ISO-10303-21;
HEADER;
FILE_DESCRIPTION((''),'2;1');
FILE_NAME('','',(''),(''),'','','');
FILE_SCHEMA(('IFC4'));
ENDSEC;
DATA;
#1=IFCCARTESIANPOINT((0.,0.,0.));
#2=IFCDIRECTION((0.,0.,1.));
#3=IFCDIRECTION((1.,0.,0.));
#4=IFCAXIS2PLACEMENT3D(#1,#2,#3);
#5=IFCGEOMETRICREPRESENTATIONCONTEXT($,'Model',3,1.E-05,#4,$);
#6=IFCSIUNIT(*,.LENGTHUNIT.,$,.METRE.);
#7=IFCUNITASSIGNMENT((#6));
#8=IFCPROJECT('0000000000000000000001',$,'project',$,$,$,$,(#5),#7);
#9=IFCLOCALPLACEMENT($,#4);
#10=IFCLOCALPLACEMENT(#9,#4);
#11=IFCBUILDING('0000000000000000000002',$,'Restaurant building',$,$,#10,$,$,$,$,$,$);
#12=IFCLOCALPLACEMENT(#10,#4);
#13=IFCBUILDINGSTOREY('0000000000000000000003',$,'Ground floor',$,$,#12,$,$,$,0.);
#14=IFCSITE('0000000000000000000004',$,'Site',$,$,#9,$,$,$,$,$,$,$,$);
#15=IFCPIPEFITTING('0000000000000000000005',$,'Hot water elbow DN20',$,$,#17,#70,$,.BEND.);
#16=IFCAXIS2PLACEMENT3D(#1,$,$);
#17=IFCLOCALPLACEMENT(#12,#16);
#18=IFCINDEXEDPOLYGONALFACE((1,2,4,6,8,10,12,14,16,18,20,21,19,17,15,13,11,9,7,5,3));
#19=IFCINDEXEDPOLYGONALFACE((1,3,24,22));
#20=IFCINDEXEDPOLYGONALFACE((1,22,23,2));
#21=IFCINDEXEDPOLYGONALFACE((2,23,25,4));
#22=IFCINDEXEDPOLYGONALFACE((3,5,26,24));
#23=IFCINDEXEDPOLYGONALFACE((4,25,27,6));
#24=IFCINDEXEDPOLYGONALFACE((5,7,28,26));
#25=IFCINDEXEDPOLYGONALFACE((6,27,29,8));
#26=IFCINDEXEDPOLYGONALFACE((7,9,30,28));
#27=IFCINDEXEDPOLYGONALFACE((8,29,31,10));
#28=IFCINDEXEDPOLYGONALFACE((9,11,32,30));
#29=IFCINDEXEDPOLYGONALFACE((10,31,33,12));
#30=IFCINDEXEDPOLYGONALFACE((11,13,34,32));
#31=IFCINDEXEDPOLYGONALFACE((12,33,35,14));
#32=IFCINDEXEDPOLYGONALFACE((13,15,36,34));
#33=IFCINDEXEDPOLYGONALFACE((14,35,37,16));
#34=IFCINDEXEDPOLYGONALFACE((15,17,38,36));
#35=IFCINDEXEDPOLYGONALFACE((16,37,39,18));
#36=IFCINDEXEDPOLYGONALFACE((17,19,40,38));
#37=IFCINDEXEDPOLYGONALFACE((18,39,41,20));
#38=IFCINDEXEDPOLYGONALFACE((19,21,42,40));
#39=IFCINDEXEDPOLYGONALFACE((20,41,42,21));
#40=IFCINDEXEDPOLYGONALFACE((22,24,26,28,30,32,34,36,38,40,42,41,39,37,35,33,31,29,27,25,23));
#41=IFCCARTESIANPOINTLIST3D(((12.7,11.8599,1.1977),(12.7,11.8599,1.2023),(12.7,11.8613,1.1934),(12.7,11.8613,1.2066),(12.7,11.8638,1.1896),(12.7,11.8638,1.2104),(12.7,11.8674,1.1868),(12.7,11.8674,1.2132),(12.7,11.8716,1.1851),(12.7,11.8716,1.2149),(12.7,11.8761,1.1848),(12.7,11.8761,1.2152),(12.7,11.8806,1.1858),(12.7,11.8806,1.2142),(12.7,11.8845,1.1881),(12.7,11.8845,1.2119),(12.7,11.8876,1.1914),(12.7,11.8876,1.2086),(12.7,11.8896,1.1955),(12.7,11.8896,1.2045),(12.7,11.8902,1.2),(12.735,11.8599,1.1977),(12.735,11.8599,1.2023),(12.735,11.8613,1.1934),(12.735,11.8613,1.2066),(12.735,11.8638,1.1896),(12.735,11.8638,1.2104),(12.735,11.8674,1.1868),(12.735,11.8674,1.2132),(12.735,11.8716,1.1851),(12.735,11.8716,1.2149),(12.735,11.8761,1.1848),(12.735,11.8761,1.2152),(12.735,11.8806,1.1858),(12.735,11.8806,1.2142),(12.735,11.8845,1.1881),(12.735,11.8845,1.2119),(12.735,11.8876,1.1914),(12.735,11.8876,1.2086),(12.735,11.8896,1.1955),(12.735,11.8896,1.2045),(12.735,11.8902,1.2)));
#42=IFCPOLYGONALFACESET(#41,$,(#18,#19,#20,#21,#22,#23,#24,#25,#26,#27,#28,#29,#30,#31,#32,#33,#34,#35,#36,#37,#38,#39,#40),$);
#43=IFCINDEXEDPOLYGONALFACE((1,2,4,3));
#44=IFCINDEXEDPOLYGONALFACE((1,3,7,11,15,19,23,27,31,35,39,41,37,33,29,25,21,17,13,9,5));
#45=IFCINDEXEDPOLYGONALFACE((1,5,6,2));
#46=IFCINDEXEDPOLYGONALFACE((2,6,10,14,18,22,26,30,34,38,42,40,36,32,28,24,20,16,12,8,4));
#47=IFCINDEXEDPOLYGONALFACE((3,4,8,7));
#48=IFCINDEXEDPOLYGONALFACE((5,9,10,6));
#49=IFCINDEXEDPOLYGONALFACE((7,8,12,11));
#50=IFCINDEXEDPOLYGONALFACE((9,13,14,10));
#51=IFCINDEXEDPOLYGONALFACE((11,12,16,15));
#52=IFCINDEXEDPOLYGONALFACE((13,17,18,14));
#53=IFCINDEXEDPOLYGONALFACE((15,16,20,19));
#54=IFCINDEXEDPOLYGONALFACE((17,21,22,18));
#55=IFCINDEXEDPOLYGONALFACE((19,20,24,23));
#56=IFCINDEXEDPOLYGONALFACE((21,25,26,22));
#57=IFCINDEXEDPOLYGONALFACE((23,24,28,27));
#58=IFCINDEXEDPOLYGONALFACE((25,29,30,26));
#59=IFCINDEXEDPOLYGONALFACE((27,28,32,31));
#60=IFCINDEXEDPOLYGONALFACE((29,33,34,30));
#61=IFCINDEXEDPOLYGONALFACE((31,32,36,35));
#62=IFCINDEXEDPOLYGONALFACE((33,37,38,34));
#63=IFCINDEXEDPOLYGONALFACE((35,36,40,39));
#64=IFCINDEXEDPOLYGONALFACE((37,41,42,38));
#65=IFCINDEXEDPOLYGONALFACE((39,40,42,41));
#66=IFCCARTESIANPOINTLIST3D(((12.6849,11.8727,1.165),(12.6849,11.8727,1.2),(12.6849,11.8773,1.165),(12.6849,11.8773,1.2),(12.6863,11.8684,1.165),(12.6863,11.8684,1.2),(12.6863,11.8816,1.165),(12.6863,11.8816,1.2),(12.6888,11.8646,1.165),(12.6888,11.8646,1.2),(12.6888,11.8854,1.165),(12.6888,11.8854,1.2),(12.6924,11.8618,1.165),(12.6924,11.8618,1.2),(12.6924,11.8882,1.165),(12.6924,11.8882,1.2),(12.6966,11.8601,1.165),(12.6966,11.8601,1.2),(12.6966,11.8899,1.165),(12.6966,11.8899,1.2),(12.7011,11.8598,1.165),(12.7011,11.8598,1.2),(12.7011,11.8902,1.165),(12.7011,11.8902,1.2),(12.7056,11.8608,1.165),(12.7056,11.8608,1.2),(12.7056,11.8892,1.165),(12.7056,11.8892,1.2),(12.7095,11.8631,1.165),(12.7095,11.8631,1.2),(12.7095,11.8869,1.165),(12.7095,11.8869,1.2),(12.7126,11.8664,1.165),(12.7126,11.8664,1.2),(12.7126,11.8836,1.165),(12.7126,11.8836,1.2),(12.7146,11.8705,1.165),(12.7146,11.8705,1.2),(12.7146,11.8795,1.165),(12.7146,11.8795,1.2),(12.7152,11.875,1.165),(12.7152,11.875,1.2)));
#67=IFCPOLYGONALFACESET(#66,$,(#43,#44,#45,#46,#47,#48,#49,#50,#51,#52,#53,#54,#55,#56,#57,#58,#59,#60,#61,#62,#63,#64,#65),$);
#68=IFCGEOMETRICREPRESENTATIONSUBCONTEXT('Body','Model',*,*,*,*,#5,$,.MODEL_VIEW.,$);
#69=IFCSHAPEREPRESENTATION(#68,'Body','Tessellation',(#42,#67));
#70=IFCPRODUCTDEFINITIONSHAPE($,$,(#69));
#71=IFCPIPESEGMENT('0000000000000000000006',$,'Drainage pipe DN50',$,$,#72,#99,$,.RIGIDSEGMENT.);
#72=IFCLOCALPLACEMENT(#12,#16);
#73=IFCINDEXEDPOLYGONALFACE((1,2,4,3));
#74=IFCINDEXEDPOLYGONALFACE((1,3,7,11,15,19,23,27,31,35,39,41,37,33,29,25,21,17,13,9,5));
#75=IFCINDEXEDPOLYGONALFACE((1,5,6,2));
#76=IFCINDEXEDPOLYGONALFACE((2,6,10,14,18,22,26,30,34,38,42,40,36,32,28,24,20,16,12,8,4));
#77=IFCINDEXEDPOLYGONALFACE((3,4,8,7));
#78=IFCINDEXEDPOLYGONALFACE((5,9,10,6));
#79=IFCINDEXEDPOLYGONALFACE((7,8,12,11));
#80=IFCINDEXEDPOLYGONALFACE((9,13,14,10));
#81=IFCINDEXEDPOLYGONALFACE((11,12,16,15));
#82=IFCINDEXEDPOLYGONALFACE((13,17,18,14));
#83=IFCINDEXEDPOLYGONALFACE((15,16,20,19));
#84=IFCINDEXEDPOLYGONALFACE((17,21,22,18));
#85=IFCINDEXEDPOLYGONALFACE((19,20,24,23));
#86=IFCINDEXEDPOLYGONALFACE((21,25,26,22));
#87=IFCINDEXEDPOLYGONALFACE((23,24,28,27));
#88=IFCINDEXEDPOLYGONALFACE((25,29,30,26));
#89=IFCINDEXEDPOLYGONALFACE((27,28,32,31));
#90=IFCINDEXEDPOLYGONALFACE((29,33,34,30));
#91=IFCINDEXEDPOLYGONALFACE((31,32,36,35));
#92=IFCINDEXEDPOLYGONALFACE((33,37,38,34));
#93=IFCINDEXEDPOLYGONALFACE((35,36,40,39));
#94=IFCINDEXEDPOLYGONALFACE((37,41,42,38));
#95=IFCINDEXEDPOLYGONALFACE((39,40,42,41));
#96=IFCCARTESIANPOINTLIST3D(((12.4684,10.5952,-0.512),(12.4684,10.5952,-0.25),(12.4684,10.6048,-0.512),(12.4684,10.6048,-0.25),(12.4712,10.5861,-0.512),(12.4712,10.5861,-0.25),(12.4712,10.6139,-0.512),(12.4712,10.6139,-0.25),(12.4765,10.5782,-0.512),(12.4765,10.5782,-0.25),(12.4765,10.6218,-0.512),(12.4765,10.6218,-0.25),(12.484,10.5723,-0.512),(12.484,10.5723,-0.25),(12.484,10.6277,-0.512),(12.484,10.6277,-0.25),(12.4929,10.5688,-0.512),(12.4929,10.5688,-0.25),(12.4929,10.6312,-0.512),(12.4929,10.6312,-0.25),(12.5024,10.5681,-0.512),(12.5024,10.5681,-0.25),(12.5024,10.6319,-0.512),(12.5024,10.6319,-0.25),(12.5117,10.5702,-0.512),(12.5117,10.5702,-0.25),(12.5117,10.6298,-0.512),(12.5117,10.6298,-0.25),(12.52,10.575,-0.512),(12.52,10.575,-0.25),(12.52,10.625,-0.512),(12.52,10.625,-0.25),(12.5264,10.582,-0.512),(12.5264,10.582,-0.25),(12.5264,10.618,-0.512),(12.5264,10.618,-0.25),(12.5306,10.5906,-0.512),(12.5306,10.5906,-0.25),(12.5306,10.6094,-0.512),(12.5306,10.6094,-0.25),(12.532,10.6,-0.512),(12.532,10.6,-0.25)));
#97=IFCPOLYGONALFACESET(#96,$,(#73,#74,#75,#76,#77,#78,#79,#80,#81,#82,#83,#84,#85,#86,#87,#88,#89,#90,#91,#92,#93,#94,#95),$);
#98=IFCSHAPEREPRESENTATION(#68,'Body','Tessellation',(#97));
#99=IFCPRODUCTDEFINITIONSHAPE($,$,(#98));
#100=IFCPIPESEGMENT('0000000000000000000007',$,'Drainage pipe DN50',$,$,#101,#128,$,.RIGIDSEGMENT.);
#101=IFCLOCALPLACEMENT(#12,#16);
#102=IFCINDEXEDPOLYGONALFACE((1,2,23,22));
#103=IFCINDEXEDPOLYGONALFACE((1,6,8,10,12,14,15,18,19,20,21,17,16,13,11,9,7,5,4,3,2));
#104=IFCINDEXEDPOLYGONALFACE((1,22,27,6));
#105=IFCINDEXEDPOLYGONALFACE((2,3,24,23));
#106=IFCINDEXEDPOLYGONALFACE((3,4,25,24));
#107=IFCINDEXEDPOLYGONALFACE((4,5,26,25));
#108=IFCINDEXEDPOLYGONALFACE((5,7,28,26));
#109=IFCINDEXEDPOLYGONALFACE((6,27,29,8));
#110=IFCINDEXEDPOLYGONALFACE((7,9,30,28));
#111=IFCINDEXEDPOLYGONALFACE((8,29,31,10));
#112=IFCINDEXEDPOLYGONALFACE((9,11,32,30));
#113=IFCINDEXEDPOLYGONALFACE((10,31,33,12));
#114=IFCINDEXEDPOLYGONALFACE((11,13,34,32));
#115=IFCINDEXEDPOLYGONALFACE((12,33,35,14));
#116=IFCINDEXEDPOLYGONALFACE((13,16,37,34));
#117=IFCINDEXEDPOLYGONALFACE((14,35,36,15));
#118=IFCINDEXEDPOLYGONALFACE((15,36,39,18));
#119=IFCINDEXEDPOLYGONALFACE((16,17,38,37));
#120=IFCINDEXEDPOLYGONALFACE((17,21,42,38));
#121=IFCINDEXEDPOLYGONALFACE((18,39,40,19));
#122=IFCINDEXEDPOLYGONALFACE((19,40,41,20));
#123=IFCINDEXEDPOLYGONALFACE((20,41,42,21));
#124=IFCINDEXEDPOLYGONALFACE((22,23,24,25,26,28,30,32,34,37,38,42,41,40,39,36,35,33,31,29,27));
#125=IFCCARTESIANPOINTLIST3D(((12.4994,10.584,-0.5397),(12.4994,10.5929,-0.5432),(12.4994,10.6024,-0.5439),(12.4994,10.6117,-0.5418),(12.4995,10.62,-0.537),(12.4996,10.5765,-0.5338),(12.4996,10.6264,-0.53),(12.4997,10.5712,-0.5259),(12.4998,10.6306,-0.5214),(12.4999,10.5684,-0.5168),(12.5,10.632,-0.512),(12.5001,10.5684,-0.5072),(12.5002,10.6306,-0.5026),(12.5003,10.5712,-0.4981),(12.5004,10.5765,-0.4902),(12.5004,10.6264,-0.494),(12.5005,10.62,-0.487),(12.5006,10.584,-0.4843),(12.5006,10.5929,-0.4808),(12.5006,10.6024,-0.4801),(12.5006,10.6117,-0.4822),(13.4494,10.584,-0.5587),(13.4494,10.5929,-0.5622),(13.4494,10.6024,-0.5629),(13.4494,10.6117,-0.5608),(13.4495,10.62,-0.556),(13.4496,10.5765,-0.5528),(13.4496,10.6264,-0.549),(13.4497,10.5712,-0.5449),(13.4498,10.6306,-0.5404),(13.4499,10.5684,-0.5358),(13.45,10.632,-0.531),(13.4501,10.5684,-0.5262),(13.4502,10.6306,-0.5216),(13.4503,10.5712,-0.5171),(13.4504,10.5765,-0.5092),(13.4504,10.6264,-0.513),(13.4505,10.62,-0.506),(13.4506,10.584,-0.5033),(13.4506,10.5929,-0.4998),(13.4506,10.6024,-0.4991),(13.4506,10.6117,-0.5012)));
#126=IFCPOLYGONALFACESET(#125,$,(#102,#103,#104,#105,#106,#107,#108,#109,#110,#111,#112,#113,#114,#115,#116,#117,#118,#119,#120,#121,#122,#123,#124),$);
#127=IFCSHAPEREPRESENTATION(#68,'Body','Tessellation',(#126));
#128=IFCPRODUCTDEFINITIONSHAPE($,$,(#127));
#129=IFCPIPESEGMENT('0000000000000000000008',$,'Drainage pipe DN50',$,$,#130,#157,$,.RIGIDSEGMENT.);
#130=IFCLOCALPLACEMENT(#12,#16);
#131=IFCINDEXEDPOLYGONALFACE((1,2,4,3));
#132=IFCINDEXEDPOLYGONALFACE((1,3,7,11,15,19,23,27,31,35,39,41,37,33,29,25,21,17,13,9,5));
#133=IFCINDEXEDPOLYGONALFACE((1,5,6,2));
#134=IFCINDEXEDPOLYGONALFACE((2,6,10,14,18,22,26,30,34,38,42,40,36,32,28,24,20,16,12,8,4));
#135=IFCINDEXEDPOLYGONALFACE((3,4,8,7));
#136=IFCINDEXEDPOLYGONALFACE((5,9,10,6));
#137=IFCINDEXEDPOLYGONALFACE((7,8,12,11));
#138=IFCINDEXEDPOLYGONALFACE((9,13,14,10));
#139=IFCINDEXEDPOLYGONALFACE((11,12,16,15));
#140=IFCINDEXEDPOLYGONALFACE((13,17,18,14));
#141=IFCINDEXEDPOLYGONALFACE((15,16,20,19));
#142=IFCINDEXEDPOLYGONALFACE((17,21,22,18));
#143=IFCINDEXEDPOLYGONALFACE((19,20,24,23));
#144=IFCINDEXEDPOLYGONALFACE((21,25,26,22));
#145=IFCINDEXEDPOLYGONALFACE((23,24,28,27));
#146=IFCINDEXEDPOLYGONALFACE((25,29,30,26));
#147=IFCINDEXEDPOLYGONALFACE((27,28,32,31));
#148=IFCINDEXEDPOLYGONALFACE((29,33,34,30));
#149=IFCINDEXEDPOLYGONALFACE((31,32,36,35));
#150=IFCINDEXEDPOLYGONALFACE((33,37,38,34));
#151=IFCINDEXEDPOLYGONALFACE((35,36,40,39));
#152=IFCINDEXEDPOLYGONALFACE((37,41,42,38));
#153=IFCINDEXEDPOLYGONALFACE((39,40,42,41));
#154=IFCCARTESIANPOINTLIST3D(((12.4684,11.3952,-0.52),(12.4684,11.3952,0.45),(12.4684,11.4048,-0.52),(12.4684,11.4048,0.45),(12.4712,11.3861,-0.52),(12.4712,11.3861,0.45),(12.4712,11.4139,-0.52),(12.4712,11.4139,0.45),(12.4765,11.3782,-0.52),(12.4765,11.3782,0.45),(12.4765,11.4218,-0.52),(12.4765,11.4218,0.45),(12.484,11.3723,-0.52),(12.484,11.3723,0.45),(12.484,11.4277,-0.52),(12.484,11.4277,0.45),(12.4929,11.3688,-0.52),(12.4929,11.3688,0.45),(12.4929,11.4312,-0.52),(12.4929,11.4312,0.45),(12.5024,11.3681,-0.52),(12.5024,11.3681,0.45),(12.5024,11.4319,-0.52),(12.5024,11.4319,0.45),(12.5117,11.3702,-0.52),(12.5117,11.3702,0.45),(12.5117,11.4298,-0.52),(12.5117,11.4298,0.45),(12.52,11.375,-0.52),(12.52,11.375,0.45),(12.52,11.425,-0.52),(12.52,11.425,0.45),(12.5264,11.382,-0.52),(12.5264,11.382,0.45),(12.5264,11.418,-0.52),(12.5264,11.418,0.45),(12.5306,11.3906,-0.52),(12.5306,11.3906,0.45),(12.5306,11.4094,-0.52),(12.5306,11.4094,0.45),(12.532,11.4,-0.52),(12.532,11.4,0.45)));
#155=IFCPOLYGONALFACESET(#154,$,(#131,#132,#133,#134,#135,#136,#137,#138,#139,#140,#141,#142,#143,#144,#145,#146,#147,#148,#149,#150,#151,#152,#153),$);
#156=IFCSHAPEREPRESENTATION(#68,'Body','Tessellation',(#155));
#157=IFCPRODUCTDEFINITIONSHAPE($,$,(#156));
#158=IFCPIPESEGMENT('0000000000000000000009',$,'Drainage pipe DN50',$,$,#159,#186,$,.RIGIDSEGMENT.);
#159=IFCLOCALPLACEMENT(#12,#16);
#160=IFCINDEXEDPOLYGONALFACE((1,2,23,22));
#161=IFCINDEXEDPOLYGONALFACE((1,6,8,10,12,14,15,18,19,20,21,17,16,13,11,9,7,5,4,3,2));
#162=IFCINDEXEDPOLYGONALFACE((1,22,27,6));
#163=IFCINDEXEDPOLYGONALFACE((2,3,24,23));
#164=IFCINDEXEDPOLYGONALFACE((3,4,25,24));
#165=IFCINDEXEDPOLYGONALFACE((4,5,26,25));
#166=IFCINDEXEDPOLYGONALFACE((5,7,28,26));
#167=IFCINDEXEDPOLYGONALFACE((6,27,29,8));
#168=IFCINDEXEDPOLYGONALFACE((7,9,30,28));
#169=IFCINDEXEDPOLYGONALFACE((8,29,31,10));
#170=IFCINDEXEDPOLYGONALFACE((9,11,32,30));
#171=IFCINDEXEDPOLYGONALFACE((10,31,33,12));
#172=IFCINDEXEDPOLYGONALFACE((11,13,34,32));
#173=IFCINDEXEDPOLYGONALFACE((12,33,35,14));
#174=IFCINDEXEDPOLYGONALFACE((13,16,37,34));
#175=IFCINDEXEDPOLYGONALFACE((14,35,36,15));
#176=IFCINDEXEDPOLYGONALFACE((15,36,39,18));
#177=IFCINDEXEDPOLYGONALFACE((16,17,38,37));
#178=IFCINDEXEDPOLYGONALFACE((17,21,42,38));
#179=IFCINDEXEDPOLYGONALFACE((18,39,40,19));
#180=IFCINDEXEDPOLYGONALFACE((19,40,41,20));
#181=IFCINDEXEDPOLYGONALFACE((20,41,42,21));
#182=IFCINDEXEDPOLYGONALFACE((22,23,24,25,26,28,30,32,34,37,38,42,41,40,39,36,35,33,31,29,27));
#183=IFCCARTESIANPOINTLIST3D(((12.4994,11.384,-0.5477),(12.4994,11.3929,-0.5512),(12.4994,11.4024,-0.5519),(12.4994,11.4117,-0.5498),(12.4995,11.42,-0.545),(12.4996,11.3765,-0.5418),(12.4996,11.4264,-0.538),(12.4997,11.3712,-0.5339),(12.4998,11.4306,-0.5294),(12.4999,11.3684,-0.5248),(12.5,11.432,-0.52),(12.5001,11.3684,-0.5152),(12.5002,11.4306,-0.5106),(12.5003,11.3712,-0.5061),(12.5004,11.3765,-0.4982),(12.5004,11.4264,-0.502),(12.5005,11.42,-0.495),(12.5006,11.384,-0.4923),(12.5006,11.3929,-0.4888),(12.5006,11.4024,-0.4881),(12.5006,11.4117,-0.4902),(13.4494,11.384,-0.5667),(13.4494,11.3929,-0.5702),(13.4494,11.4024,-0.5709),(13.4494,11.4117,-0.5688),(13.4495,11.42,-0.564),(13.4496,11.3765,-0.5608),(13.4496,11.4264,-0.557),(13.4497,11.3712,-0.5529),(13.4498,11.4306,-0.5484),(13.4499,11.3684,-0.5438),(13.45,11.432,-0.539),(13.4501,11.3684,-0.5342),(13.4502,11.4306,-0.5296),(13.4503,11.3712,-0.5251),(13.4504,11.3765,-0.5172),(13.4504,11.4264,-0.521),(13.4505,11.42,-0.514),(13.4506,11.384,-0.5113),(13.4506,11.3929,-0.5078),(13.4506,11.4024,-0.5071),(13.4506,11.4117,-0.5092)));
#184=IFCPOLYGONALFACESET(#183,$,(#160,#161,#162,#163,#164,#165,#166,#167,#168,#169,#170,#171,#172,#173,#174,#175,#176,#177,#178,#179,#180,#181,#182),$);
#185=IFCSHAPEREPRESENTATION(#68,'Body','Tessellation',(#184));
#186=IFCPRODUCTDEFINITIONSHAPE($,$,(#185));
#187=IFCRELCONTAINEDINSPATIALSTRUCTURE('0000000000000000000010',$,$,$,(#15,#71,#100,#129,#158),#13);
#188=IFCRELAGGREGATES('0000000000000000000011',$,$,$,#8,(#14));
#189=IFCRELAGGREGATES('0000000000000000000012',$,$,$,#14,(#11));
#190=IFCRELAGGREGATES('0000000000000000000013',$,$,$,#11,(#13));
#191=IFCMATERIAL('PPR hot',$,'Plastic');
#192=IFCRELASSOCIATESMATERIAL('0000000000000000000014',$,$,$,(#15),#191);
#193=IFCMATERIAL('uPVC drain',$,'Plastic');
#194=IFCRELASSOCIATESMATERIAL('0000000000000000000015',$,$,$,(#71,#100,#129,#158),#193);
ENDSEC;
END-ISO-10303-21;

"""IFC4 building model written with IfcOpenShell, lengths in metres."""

from ifc_helpers import new_model, si_unit, frame, origin_with_axes, origin_2d, place, context, subcontext, project, spatial, circle, extrude, material, element, save


model = new_model("IFC4")

# Units and contexts
model_context = context("Model", 3, precision=1e-05, world=origin_with_axes())
body_context = subcontext(model_context, "Body", "Model", "MODEL_VIEW")
ifc_project = project(units=[si_unit("LENGTHUNIT", "METRE")], contexts=[model_context])

# Site, building, storey
site_placement = place(None, origin_with_axes())
site = spatial("IfcSite", under=ifc_project, at=site_placement, Name="Site")
building_placement = place(site_placement, origin_with_axes())
building = spatial("IfcBuilding", under=site, at=building_placement, Name="Restaurant building")
storey_placement = place(building_placement, origin_with_axes())
storey = spatial("IfcBuildingStorey", under=building, at=storey_placement, Name="Ground floor", Elevation=0.0)

# Shared definitions
ifc_material_1 = material(Name="uPVC drain", Category="Plastic")

# Shared definitions
ifc_material_2 = material(Name="PPR hot", Category="Plastic")

# Pipe fitting
pipe_fitting_1_placement = place(storey_placement, frame((12.7, 11.875, 1.2)))
element("IfcPipeFitting", 1, at=pipe_fitting_1_placement, inside=storey, material=ifc_material_2, Name="Hot water elbow DN20", PredefinedType="BEND", context=body_context, shape_type="SweptSolid", body=[
    extrude(circle(Radius=0.0152, at=origin_2d()), frame((0.0, 0.0, 0.0), z_axis=(1.0, 0.0, 0.0), x_axis=(0.0, 1.0, 0.0)), (0.0, 0.0, 1.0), 0.035),
    extrude(circle(Radius=0.0152, at=origin_2d()), frame((0.0, 0.0, 0.0), z_axis=(0.0, 0.0, -1.0), x_axis=(1.0, 0.0, 0.0)), (0.0, 0.0, 1.0), 0.035),
])

# Pipe segments
pipe_segment_1_placement = place(storey_placement, frame((12.5, 10.6, -0.25)))
element("IfcPipeSegment", 2, at=pipe_segment_1_placement, inside=storey, material=ifc_material_1, Name="Drainage pipe DN50", PredefinedType="RIGIDSEGMENT", context=body_context, shape_type="SweptSolid", body=[
    extrude(circle(Radius=0.032, at=origin_2d()), frame((0.0, 0.0, 0.0), z_axis=(0.0, 0.0, -1.0), x_axis=(1.0, 0.0, 0.0)), (0.0, 0.0, 1.0), 0.262),
])
pipe_segment_2_placement = place(storey_placement, frame((12.5, 10.6, -0.512)))
element("IfcPipeSegment", 3, at=pipe_segment_2_placement, inside=storey, material=ifc_material_1, Name="Drainage pipe DN50", PredefinedType="RIGIDSEGMENT", context=body_context, shape_type="SweptSolid", body=[
    extrude(circle(Radius=0.032, at=origin_2d()), frame((0.0, 0.0, 0.0), z_axis=(0.9998, 0.0, -0.019996), x_axis=(0.0, 1.0, 0.0)), (0.0, 0.0, 1.0), 0.9502),
])
pipe_segment_3_placement = place(storey_placement, frame((12.5, 11.4, 0.45)))
element("IfcPipeSegment", 4, at=pipe_segment_3_placement, inside=storey, material=ifc_material_1, Name="Drainage pipe DN50", PredefinedType="RIGIDSEGMENT", context=body_context, shape_type="SweptSolid", body=[
    extrude(circle(Radius=0.032, at=origin_2d()), frame((0.0, 0.0, 0.0), z_axis=(0.0, 0.0, -1.0), x_axis=(1.0, 0.0, 0.0)), (0.0, 0.0, 1.0), 0.97),
])
pipe_segment_4_placement = place(storey_placement, frame((12.5, 11.4, -0.52)))
element("IfcPipeSegment", 5, at=pipe_segment_4_placement, inside=storey, material=ifc_material_1, Name="Drainage pipe DN50", PredefinedType="RIGIDSEGMENT", context=body_context, shape_type="SweptSolid", body=[
    extrude(circle(Radius=0.032, at=origin_2d()), frame((0.0, 0.0, 0.0), z_axis=(0.9998, 0.0, -0.019996), x_axis=(0.0, 1.0, 0.0)), (0.0, 0.0, 1.0), 0.9502),
])

save(model, "model.ifc")
